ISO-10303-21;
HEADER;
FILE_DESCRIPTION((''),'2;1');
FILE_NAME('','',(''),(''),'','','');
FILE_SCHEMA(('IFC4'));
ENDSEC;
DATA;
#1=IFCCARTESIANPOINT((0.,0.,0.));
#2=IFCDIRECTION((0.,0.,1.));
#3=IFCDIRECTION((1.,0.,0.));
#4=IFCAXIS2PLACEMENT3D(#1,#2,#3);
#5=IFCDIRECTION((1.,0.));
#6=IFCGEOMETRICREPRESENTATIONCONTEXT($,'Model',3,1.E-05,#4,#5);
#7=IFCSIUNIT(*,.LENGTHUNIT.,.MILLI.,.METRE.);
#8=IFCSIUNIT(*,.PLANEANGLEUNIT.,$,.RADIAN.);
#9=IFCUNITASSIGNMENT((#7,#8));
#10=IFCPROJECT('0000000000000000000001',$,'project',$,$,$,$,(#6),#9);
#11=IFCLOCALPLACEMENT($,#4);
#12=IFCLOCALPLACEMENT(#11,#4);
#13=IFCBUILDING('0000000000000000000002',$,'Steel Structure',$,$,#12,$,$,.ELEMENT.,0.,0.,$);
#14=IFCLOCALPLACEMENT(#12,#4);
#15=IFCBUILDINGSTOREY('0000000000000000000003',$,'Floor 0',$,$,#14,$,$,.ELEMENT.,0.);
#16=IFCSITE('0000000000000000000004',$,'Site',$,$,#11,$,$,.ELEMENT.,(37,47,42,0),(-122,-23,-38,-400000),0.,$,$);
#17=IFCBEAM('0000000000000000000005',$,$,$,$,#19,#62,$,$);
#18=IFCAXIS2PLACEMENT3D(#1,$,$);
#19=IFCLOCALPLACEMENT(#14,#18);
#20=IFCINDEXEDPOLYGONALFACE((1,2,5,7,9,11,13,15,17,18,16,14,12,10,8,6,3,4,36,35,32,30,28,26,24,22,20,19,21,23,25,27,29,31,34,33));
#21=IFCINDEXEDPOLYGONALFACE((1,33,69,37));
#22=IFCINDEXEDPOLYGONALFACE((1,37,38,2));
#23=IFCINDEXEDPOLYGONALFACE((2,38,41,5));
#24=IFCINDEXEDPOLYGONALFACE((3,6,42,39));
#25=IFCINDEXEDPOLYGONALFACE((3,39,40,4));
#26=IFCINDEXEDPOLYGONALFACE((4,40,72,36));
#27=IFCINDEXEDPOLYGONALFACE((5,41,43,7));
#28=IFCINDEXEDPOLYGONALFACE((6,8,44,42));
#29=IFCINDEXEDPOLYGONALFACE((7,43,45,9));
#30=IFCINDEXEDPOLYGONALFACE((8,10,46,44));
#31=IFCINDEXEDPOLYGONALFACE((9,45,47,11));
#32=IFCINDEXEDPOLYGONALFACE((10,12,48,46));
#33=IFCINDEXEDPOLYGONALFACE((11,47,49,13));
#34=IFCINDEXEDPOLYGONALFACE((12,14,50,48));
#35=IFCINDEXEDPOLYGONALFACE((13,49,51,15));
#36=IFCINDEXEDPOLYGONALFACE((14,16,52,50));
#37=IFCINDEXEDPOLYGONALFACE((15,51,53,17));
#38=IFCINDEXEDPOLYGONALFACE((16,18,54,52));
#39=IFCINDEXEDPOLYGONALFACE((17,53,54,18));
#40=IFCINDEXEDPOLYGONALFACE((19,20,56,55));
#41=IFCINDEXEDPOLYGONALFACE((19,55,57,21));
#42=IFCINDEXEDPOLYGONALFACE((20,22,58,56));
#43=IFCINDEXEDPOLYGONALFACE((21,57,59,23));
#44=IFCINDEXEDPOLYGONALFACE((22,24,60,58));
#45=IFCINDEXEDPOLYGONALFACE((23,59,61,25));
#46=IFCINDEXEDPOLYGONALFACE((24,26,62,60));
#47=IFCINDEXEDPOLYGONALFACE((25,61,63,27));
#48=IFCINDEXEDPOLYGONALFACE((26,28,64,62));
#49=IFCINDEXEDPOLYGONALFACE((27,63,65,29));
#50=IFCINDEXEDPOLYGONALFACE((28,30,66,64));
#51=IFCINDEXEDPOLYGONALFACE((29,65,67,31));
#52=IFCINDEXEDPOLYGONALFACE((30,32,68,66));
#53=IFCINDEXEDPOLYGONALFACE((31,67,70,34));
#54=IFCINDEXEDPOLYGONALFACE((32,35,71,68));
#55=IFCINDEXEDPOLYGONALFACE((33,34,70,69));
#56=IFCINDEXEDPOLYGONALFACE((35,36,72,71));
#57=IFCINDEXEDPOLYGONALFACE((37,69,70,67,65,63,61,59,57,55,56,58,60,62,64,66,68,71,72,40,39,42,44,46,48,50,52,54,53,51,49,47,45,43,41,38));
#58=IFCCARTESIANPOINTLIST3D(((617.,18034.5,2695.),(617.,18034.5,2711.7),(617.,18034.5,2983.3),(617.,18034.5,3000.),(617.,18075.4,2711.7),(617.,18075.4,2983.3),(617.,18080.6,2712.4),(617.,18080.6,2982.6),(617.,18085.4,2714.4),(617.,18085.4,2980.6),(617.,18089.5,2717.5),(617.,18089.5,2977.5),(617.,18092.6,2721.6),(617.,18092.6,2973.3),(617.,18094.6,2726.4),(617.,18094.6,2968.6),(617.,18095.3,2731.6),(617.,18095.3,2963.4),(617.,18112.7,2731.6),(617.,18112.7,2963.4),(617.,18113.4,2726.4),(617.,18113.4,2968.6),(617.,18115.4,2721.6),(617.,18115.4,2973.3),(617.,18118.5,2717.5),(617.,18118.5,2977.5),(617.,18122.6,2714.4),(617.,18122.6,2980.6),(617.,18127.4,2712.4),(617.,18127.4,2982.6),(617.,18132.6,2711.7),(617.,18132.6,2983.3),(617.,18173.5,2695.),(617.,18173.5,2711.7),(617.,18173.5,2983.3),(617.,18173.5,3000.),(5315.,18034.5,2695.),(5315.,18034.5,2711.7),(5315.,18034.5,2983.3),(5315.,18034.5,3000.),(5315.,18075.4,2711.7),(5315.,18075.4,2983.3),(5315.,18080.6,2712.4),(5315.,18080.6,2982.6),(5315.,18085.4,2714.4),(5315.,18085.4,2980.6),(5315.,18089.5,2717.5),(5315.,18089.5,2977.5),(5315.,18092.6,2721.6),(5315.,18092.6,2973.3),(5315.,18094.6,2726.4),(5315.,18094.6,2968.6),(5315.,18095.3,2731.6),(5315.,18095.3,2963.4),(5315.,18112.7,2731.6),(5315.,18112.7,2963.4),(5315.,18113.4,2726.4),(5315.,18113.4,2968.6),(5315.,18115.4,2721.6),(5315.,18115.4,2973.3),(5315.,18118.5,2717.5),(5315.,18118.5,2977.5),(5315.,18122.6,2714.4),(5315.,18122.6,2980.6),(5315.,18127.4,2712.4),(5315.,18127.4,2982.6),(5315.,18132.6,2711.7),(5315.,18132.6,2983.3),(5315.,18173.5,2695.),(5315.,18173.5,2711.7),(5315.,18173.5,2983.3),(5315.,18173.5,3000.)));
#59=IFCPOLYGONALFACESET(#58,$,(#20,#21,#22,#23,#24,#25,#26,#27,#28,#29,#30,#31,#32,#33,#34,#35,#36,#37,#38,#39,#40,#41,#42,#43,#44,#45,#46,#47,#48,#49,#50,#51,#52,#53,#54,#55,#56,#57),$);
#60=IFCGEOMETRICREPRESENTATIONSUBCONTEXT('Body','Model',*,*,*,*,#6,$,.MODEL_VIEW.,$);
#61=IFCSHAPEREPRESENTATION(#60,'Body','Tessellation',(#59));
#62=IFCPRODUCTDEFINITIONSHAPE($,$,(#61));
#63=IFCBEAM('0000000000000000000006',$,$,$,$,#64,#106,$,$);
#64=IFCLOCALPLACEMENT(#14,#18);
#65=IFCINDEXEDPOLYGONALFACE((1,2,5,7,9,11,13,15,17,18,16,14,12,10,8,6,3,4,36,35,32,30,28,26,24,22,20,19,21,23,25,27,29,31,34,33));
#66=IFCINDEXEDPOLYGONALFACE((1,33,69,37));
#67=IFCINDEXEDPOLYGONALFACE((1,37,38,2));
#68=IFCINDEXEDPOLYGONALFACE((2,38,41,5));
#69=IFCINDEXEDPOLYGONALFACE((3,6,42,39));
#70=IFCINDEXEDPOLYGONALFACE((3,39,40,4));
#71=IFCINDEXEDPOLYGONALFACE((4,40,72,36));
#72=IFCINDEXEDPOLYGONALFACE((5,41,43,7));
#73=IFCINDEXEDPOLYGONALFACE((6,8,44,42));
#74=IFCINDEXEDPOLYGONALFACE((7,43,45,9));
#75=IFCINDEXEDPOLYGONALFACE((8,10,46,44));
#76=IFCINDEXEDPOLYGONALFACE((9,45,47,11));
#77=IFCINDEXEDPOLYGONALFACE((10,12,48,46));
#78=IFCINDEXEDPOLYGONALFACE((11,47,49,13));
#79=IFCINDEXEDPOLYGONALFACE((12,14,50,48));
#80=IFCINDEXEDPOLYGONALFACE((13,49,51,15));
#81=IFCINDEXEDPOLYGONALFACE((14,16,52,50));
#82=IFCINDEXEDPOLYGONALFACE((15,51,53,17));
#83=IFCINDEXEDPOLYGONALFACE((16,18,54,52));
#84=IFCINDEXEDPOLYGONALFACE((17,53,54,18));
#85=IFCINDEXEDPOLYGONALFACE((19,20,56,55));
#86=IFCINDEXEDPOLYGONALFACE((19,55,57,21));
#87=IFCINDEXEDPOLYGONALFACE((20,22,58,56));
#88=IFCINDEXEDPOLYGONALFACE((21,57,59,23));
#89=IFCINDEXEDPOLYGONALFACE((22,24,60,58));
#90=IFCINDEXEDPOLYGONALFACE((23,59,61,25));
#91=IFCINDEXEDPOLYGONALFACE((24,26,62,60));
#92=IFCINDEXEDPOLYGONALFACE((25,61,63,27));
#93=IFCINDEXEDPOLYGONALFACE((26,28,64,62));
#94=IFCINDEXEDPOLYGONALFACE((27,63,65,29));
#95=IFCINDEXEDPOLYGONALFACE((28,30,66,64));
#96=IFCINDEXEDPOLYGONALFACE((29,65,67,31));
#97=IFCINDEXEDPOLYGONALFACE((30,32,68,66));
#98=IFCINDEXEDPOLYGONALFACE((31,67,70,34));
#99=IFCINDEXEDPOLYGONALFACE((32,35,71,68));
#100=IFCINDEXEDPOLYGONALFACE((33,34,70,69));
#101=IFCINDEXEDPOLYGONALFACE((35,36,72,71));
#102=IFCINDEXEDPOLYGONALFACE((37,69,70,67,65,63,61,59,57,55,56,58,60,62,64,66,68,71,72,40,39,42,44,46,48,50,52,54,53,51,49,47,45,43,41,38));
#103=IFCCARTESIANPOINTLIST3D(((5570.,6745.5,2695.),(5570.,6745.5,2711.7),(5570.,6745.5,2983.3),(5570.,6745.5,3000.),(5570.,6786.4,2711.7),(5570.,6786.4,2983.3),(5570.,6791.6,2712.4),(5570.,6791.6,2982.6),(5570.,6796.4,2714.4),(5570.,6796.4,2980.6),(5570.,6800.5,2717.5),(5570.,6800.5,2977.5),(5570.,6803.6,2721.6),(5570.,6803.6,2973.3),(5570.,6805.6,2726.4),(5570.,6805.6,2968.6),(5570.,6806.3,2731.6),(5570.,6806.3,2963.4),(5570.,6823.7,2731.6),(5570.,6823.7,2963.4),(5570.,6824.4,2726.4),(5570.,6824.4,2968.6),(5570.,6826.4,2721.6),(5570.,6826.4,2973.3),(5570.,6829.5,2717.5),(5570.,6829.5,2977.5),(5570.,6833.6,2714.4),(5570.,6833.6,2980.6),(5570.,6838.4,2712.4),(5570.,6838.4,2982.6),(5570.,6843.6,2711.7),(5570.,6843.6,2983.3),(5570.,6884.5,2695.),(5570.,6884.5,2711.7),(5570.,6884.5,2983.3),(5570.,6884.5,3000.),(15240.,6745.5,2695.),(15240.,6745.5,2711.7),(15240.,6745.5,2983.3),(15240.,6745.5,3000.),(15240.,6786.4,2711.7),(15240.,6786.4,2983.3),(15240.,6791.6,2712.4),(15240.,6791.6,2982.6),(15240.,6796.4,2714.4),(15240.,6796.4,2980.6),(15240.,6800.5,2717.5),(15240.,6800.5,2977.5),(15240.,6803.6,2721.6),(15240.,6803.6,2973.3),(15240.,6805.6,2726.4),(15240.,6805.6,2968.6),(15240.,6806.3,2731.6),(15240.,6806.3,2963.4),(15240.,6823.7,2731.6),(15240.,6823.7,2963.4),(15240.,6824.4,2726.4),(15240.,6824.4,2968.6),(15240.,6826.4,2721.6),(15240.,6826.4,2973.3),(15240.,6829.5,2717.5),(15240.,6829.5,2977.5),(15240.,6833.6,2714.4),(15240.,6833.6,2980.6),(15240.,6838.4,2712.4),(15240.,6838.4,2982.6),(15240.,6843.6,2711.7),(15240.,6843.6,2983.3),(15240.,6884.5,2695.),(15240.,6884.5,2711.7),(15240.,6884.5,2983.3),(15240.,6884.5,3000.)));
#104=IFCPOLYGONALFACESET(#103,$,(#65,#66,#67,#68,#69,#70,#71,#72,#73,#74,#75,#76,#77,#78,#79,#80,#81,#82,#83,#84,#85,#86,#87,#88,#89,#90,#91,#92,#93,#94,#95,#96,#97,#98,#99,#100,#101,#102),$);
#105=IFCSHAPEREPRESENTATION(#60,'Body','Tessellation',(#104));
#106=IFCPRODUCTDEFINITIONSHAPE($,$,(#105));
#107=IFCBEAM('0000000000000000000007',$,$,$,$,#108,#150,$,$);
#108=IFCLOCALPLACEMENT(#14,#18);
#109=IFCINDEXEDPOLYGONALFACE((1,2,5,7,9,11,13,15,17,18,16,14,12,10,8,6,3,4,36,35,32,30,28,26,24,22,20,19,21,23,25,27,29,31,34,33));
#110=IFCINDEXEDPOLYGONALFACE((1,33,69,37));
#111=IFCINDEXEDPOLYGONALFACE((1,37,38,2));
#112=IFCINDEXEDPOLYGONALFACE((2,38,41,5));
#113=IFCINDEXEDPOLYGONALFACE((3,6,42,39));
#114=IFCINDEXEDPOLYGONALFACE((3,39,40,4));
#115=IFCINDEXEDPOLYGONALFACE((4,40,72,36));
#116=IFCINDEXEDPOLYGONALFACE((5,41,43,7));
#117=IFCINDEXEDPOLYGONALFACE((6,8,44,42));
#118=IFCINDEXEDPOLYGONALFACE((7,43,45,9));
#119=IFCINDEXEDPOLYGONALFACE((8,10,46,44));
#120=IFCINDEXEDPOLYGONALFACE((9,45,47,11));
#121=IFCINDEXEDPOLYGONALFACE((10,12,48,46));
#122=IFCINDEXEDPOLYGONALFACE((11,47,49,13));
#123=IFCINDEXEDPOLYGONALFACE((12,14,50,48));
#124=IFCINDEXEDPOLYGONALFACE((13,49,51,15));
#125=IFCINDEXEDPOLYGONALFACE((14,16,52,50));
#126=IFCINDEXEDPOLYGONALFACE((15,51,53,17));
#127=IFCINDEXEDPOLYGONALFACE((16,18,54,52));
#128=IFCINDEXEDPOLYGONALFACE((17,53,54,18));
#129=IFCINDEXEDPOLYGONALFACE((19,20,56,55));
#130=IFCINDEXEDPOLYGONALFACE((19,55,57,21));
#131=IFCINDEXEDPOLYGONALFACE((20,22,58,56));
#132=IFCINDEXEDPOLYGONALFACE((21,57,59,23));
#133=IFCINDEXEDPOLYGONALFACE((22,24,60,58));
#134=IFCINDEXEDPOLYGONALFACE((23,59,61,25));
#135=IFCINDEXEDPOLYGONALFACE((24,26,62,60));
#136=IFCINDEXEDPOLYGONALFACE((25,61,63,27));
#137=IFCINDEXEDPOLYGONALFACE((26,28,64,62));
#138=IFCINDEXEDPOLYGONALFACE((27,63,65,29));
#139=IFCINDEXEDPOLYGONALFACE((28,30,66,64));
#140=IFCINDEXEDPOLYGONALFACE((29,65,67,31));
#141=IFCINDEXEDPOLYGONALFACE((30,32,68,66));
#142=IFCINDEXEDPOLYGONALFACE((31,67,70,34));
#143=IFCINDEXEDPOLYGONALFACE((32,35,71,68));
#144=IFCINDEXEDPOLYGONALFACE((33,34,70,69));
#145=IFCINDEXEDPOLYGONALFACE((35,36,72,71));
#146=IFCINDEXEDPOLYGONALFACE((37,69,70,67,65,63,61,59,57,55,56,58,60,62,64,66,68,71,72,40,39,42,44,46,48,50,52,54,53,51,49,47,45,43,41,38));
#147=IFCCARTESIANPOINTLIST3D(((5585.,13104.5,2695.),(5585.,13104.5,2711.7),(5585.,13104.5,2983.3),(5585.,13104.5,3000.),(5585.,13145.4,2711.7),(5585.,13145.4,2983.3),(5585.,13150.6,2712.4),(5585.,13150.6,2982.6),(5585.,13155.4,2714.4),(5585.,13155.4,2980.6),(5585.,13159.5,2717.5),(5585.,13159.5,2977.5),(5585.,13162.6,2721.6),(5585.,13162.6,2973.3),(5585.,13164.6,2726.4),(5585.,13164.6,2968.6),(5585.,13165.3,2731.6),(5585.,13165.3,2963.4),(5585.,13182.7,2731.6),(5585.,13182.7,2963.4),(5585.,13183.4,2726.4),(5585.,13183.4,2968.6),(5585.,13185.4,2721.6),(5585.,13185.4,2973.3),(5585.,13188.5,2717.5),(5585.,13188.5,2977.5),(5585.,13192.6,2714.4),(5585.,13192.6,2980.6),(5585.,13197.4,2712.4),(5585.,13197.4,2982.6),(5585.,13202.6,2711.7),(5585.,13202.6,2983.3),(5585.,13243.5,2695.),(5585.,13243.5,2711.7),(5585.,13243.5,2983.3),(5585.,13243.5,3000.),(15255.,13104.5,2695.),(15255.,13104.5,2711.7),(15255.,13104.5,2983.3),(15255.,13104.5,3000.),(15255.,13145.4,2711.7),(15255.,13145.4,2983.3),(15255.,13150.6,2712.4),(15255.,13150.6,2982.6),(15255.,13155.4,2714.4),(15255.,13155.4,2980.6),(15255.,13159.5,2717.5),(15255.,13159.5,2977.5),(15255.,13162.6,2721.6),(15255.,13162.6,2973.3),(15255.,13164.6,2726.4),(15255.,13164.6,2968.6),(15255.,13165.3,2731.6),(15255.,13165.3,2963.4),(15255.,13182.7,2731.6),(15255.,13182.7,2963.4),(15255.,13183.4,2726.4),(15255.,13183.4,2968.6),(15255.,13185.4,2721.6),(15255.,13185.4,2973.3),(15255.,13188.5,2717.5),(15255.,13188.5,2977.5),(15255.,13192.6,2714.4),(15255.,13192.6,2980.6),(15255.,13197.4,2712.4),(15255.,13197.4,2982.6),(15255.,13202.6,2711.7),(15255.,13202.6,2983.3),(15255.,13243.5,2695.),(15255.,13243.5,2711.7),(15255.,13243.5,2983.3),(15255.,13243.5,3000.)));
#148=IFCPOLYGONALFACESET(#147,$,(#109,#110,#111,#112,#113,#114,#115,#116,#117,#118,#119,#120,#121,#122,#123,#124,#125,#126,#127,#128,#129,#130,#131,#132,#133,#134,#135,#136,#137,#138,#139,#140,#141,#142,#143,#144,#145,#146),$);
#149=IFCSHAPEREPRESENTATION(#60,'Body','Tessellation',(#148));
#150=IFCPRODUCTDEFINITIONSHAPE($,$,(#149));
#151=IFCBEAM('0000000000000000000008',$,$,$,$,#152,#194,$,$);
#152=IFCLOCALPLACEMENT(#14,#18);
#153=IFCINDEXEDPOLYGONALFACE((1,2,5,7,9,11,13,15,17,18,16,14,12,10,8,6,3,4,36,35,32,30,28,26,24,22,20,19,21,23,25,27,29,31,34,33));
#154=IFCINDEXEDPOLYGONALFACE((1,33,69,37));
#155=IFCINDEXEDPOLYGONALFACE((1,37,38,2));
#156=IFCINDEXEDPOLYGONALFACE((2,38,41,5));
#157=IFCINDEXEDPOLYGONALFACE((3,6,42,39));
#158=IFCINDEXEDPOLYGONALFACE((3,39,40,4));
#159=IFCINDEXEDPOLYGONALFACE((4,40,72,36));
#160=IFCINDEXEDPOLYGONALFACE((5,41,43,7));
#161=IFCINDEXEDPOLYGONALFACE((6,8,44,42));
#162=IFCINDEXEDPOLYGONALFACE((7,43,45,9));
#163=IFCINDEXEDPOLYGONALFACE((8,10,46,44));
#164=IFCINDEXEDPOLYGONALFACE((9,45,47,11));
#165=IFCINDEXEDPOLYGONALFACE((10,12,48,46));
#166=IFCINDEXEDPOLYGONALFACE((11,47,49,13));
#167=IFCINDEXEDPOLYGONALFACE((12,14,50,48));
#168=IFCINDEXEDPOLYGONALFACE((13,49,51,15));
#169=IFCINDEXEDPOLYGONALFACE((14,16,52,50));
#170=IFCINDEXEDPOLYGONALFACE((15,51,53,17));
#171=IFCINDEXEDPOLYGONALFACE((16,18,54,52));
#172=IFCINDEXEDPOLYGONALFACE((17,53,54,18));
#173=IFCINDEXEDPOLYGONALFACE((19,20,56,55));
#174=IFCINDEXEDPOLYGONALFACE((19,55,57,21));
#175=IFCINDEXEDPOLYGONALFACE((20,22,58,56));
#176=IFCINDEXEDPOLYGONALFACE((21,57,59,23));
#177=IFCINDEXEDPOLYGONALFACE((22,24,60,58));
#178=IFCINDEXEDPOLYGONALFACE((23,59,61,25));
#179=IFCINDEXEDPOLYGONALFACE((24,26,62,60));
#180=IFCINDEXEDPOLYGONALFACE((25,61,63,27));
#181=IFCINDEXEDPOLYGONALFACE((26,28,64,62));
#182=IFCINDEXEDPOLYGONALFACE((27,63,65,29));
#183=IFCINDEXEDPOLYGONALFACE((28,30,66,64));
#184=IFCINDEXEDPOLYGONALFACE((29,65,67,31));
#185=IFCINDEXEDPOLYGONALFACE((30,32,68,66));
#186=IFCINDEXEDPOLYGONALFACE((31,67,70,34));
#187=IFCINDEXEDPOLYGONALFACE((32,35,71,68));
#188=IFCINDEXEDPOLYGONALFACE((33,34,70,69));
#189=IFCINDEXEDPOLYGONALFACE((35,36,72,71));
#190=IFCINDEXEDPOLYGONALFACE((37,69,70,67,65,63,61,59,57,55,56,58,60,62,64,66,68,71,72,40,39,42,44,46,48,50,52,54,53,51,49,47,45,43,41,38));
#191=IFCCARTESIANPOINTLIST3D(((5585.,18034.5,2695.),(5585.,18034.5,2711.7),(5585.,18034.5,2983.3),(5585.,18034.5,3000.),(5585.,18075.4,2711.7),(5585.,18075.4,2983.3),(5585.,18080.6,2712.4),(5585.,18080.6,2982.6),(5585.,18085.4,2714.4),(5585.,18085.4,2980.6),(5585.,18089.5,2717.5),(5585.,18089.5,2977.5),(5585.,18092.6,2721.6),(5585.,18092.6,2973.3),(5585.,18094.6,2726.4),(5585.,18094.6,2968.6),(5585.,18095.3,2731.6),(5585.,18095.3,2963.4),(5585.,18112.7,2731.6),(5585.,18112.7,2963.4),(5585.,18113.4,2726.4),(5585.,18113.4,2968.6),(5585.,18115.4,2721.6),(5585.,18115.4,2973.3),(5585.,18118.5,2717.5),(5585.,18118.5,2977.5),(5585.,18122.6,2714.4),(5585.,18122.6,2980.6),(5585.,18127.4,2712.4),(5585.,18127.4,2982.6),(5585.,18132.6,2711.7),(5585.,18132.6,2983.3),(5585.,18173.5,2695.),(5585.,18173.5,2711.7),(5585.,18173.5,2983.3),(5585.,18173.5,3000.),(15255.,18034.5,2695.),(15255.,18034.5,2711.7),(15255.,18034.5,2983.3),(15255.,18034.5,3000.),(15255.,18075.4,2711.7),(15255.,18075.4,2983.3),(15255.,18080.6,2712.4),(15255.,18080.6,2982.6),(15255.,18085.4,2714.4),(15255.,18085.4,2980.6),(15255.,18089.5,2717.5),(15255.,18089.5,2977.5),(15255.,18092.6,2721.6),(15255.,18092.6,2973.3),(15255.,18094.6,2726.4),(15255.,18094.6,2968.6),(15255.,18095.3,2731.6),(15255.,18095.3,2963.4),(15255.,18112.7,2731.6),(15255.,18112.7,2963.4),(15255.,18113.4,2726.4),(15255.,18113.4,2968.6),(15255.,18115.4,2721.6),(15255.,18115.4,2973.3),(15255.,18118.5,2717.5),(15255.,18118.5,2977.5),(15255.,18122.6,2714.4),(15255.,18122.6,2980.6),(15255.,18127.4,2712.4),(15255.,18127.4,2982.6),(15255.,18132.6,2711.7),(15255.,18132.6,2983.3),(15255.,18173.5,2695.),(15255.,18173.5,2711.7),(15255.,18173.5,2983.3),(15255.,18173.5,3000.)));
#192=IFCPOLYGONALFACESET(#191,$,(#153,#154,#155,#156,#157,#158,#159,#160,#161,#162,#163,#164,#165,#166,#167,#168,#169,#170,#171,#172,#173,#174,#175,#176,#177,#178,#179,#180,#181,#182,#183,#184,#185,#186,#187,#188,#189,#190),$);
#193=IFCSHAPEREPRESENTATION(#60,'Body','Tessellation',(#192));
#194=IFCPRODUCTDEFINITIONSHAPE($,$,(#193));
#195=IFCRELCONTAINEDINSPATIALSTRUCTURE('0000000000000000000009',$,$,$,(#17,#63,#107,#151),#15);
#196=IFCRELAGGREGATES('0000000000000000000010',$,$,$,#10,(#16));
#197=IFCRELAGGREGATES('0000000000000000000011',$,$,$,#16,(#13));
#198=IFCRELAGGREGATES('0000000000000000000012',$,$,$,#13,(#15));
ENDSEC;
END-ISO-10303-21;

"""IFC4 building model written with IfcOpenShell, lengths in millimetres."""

from ifc_helpers import new_model, si_unit, direction, frame, origin_with_axes, origin_2d_with_axis, place, context, subcontext, project, spatial, i_section, extrude, element, save


model = new_model("IFC4")

# Units and contexts
model_context = context("Model", 3, precision=1e-05, world=origin_with_axes(), true_north=direction((1.0, 0.0)))
body_context = subcontext(model_context, "Body", "Model", "MODEL_VIEW")
ifc_project = project(units=[si_unit("LENGTHUNIT", "METRE", prefix="MILLI"), si_unit("PLANEANGLEUNIT", "RADIAN")], contexts=[model_context])

# Site, building, storey
site_placement = place(None, origin_with_axes())
site = spatial("IfcSite", under=ifc_project, at=site_placement, Name="Site", CompositionType="ELEMENT", RefLatitude=(37, 47, 42, 0), RefLongitude=(-122, -23, -38, -400000), RefElevation=0.0)
building_placement = place(site_placement, origin_with_axes())
building = spatial("IfcBuilding", under=site, at=building_placement, Name="Steel Structure", CompositionType="ELEMENT", ElevationOfRefHeight=0.0, ElevationOfTerrain=0.0)
storey_placement = place(building_placement, origin_with_axes())
storey = spatial("IfcBuildingStorey", under=building, at=storey_placement, Name="Floor 0", CompositionType="ELEMENT", Elevation=0.0)

# Beams
beam_1_placement = place(storey_placement, frame((5315.0, 18104.0, 2695.0), z_axis=(-1.0, 0.0, 0.0), x_axis=(0.0, -1.0, 0.0)))
element("IfcBeam", 1, at=beam_1_placement, inside=storey, context=body_context, shape_type="SweptSolid", body=[
    extrude(i_section(OverallWidth=139.0, OverallDepth=305.0, WebThickness=17.4, FlangeThickness=16.7, FilletRadius=19.9, at=origin_2d_with_axis()), frame((0.0, 152.5, 0.0), z_axis=(0.0, 0.0, 1.0), x_axis=(1.0, 0.0, 0.0)), (0.0, 0.0, 1.0), 4698.0),
])
beam_2_placement = place(storey_placement, frame((5570.0, 6815.0, 2695.0), z_axis=(1.0, 0.0, 0.0), x_axis=(0.0, 1.0, 0.0)))
element("IfcBeam", 2, at=beam_2_placement, inside=storey, context=body_context, shape_type="SweptSolid", body=[
    extrude(i_section(OverallWidth=139.0, OverallDepth=305.0, WebThickness=17.4, FlangeThickness=16.7, FilletRadius=19.9, at=origin_2d_with_axis()), frame((0.0, 152.5, 0.0), z_axis=(0.0, 0.0, 1.0), x_axis=(1.0, 0.0, 0.0)), (0.0, 0.0, 1.0), 9670.0),
])
for number, where, z_axis, x_axis in (
    (3, (15255.0, 13174.0, 2695.0), (-1.0, 0.0, 0.0), (0.0, -1.0, 0.0)),
    (4, (15255.0, 18104.0, 2695.0), (-1.0, 0.0, 0.0), (0.0, -1.0, 0.0)),
):
    element("IfcBeam", number, at=place(storey_placement, frame(where, z_axis=z_axis, x_axis=x_axis)), inside=storey, context=body_context, shape_type="SweptSolid", body=[
        extrude(i_section(OverallWidth=139.0, OverallDepth=305.0, WebThickness=17.4, FlangeThickness=16.7, FilletRadius=19.9, at=origin_2d_with_axis()), frame((0.0, 152.5, 0.0), z_axis=(0.0, 0.0, 1.0), x_axis=(1.0, 0.0, 0.0)), (0.0, 0.0, 1.0), 9670.0),
    ])

save(model, "model.ifc")
